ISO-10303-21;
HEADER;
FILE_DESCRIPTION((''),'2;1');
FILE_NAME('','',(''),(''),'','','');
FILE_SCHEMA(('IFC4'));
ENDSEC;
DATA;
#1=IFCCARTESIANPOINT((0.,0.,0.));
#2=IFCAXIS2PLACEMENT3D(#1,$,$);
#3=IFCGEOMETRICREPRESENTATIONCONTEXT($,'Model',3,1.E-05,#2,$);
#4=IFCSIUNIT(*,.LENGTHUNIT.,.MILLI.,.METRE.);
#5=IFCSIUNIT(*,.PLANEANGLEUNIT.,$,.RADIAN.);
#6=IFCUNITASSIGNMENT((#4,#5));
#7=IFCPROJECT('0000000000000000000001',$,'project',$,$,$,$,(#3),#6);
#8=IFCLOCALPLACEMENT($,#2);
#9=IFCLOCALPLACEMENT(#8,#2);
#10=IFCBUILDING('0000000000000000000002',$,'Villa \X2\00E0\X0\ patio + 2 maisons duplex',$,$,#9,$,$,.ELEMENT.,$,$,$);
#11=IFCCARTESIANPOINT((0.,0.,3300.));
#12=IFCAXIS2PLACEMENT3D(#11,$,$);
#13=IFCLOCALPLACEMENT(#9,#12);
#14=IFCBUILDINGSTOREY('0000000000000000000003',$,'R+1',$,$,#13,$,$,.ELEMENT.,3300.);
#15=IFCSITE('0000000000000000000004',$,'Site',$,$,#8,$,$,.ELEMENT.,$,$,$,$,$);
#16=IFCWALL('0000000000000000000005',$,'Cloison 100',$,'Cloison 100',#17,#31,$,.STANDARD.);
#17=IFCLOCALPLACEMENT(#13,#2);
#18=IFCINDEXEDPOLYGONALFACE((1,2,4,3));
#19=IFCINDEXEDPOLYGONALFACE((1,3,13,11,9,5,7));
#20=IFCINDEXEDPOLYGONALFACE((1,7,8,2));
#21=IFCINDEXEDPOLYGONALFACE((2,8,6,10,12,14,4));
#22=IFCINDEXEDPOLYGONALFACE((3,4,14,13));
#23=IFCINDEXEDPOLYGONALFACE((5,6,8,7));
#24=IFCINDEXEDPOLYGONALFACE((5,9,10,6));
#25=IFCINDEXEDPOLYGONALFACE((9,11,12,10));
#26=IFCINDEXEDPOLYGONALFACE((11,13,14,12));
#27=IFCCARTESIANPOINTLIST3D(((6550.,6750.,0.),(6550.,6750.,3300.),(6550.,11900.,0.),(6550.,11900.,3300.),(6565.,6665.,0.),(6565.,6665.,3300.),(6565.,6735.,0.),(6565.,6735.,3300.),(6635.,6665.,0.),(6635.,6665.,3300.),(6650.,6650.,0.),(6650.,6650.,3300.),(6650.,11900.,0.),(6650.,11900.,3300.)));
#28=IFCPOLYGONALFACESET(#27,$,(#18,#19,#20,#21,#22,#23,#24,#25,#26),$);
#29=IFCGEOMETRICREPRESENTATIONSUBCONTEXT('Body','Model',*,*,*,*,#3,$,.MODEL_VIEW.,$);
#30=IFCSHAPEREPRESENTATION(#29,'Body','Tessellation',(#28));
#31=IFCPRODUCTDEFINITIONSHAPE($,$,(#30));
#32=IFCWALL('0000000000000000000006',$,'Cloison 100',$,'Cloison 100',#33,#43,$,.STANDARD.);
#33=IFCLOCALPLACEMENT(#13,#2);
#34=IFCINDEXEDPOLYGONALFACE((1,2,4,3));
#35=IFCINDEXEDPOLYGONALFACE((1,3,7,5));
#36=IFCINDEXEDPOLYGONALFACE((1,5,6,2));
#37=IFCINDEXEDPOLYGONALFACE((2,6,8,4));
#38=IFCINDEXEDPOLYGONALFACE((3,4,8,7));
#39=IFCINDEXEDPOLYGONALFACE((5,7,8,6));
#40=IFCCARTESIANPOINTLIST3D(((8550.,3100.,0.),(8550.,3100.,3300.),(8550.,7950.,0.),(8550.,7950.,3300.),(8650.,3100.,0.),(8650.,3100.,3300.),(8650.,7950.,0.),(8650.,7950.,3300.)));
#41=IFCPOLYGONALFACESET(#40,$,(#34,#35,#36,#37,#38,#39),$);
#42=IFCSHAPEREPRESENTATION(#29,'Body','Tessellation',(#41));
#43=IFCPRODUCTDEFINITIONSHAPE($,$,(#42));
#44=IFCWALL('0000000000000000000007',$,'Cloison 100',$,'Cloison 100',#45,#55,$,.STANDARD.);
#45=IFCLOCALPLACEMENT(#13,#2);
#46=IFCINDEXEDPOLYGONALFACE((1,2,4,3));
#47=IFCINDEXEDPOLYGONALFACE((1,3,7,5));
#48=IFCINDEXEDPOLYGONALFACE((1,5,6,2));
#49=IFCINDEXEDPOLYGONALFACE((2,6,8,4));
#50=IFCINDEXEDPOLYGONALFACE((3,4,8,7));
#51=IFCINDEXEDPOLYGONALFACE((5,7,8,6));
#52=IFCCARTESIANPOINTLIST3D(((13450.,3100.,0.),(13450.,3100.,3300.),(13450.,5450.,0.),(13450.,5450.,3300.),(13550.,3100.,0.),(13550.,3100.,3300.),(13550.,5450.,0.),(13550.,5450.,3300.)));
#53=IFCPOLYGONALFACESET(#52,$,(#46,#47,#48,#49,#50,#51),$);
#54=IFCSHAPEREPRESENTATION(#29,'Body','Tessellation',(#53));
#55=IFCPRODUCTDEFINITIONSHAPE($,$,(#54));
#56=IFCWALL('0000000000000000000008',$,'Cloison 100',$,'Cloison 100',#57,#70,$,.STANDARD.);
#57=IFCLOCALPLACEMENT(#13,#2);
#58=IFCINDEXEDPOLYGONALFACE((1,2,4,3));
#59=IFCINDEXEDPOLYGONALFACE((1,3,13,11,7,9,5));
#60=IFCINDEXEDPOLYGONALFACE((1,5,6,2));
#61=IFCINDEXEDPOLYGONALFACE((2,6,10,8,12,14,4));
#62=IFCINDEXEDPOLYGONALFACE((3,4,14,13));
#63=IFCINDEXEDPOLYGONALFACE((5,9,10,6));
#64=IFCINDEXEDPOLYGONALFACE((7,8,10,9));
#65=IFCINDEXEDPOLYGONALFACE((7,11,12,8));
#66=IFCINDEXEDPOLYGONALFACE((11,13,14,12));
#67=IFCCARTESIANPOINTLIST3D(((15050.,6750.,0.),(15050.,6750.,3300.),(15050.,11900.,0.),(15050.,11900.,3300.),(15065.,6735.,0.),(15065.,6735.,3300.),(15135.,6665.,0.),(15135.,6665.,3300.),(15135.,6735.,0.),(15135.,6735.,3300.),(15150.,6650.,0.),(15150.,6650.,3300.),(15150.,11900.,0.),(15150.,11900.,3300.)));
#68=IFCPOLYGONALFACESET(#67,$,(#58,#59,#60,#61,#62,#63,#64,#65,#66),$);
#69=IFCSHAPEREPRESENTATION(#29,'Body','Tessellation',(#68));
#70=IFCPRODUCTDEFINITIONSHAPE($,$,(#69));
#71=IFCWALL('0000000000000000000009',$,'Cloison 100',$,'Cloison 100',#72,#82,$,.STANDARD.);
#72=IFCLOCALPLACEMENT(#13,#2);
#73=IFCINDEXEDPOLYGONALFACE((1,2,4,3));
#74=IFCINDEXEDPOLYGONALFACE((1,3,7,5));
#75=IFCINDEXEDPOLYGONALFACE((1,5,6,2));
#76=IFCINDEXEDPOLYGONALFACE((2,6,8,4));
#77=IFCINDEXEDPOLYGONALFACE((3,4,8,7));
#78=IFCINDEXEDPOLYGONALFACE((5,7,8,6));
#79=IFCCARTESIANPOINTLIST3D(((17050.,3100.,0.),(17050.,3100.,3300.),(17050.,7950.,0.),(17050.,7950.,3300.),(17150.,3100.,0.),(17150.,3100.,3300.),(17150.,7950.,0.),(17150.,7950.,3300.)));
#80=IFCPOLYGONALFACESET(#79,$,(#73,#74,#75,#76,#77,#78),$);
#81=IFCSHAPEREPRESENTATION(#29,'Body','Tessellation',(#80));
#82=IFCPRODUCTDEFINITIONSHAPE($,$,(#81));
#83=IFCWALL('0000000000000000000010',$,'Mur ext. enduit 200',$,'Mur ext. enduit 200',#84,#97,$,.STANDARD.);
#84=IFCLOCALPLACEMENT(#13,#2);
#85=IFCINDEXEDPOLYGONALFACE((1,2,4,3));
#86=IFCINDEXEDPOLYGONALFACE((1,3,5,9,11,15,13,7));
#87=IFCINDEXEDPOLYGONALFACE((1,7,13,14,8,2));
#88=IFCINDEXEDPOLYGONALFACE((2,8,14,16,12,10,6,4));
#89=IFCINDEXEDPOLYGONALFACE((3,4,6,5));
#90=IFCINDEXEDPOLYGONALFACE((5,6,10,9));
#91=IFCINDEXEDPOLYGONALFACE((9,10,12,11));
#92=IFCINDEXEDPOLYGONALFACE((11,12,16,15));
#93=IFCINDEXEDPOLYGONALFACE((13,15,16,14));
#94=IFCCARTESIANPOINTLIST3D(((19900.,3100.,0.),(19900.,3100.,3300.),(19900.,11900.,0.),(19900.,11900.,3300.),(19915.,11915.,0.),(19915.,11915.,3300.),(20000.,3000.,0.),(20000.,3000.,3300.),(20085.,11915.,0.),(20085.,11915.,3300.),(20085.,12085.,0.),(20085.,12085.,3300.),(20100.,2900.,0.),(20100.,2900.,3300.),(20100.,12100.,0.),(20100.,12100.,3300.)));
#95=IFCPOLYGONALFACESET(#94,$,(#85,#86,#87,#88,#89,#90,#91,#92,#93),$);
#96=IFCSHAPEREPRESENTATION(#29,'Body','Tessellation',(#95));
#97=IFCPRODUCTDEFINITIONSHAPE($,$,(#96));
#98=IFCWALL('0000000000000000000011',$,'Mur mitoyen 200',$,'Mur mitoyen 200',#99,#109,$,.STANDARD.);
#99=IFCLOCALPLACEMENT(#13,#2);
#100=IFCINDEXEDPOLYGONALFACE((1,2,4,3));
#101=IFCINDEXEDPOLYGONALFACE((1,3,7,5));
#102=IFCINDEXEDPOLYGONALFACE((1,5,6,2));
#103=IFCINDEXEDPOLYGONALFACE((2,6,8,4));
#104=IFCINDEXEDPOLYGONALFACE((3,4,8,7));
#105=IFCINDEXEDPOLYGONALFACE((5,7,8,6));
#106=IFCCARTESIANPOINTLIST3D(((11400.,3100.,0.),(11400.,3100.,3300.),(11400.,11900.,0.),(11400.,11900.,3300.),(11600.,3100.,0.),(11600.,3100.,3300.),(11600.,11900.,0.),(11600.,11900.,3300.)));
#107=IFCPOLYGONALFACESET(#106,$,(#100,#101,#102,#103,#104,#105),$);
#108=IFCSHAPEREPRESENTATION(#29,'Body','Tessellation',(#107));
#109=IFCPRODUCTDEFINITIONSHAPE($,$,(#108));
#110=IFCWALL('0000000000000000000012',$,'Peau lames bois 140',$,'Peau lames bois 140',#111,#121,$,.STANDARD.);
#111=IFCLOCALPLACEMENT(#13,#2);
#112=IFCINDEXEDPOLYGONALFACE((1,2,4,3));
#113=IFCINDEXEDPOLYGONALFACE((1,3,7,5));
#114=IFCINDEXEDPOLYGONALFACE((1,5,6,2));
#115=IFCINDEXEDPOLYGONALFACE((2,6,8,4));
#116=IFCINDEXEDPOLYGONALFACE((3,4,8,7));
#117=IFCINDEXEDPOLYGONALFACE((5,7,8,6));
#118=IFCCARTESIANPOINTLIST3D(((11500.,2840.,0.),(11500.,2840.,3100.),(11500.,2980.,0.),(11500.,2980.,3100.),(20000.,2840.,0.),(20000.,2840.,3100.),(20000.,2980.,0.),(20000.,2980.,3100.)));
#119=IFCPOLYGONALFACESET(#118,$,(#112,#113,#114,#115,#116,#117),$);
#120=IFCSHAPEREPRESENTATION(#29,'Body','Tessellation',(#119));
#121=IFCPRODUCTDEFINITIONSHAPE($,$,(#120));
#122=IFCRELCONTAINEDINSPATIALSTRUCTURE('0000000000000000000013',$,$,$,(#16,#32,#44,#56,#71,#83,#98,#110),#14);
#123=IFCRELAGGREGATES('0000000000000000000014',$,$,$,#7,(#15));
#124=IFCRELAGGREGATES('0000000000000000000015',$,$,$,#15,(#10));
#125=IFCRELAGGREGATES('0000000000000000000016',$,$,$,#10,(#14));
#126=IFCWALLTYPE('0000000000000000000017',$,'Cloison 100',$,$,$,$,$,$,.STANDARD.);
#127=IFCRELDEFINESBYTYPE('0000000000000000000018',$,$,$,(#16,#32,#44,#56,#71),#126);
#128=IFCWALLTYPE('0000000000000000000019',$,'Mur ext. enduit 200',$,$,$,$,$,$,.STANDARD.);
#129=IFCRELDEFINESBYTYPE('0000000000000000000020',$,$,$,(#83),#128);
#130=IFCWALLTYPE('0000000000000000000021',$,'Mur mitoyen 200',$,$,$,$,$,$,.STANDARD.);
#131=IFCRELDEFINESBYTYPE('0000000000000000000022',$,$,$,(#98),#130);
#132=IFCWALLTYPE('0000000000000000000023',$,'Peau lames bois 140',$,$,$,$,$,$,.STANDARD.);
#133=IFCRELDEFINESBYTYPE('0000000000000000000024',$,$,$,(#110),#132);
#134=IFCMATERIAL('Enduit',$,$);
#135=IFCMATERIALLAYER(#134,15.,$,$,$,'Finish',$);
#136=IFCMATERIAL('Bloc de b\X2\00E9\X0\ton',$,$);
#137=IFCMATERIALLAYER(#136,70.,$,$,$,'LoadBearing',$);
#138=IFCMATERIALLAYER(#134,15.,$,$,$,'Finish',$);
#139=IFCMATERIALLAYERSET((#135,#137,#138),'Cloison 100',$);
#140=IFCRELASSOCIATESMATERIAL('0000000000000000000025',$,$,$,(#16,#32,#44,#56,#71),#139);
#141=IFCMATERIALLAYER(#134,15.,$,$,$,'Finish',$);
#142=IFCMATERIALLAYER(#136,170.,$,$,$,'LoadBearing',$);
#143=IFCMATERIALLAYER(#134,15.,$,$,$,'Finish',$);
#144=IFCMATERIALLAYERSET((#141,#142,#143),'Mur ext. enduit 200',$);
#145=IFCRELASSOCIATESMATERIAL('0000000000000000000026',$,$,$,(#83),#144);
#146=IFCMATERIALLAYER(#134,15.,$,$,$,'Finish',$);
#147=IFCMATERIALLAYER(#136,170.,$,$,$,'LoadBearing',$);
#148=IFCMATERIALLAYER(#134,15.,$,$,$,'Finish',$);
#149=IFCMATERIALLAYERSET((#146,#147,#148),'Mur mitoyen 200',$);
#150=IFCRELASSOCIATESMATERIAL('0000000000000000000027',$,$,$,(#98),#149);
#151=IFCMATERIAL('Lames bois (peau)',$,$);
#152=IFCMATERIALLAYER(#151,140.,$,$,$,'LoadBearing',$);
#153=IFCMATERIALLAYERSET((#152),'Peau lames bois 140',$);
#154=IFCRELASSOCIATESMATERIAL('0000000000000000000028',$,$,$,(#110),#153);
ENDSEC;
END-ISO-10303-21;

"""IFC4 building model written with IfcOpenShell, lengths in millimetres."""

from ifc_helpers import new_model, si_unit, frame, origin, place, context, subcontext, project, spatial, polyline, outline, extrude, material, layer, layer_set, layer_usage, type_object, element, save


model = new_model("IFC4")

# Units and contexts
model_context = context("Model", 3, precision=1e-05, world=origin())
body_context = subcontext(model_context, "Body", "Model", "MODEL_VIEW")
ifc_project = project(units=[si_unit("LENGTHUNIT", "METRE", prefix="MILLI"), si_unit("PLANEANGLEUNIT", "RADIAN")], contexts=[model_context])

# Site, building, storey
site_placement = place(None, origin())
site = spatial("IfcSite", under=ifc_project, at=site_placement, Name="Site", CompositionType="ELEMENT")
building_placement = place(site_placement, origin())
building = spatial("IfcBuilding", under=site, at=building_placement, Name="Villa à patio + 2 maisons duplex", CompositionType="ELEMENT")
storey_placement = place(building_placement, frame((0.0, 0.0, 3300.0)))
storey = spatial("IfcBuildingStorey", under=building, at=storey_placement, Name="R+1", CompositionType="ELEMENT", Elevation=3300.0)

# Shared definitions
ifc_material_1 = material(Name="Enduit")
ifc_layer_1 = layer(ifc_material_1, 15.0, Category="Finish")
ifc_material_2 = material(Name="Bloc de béton")
ifc_layer_2 = layer(ifc_material_2, 70.0, Category="LoadBearing")
ifc_layer_3 = layer(ifc_material_1, 15.0, Category="Finish")
ifc_layer_set_1 = layer_set([ifc_layer_1, ifc_layer_2, ifc_layer_3], Name="Cloison 100")
ifc_layer_usage_1 = layer_usage(ifc_layer_set_1, "AXIS2", "NEGATIVE", 50.0)
wall_type_1 = type_object("IfcWallType", Name="Cloison 100", PredefinedType="STANDARD")

# Walls
wall_1_placement = place(storey_placement, frame((6600.0, 12000.0, 0.0), z_axis=(0.0, 0.0, 1.0), x_axis=(0.0, -1.0, 0.0)))
element("IfcWall", 1, at=wall_1_placement, inside=storey, type_object=wall_type_1, material=ifc_layer_usage_1, Name="Cloison 100", ObjectType="Cloison 100", PredefinedType="STANDARD", context=body_context, shape_type="SweptSolid", body=[
    extrude(outline(polyline([(100.0, -50.0), (100.0, 50.0), (5350.0, 50.0), (5335.0, 35.0), (5335.0, -35.0), (5265.0, -35.0), (5250.0, -50.0), (100.0, -50.0)])), origin(), (0.0, 0.0, 1.0), 3300.0),
])
wall_2_placement = place(storey_placement, frame((8600.0, 8000.0, 0.0), z_axis=(0.0, 0.0, 1.0), x_axis=(0.0, -1.0, 0.0)))
element("IfcWall", 2, at=wall_2_placement, inside=storey, type_object=wall_type_1, material=ifc_layer_usage_1, Name="Cloison 100", ObjectType="Cloison 100", PredefinedType="STANDARD", context=body_context, shape_type="SweptSolid", body=[
    extrude(outline(polyline([(50.0, -50.0), (50.0, 50.0), (4900.0, 50.0), (4900.0, -50.0), (50.0, -50.0)])), origin(), (0.0, 0.0, 1.0), 3300.0),
])
wall_3_placement = place(storey_placement, frame((13500.0, 5500.0, 0.0), z_axis=(0.0, 0.0, 1.0), x_axis=(0.0, -1.0, 0.0)))
element("IfcWall", 3, at=wall_3_placement, inside=storey, type_object=wall_type_1, material=ifc_layer_usage_1, Name="Cloison 100", ObjectType="Cloison 100", PredefinedType="STANDARD", context=body_context, shape_type="SweptSolid", body=[
    extrude(outline(polyline([(50.0, -50.0), (50.0, 50.0), (2400.0, 50.0), (2400.0, -50.0), (50.0, -50.0)])), origin(), (0.0, 0.0, 1.0), 3300.0),
])
wall_4_placement = place(storey_placement, frame((15100.0, 12000.0, 0.0), z_axis=(0.0, 0.0, 1.0), x_axis=(0.0, -1.0, 0.0)))
element("IfcWall", 4, at=wall_4_placement, inside=storey, type_object=wall_type_1, material=ifc_layer_usage_1, Name="Cloison 100", ObjectType="Cloison 100", PredefinedType="STANDARD", context=body_context, shape_type="SweptSolid", body=[
    extrude(outline(polyline([(100.0, -50.0), (100.0, 50.0), (5350.0, 50.0), (5335.0, 35.0), (5265.0, 35.0), (5265.0, -35.0), (5250.0, -50.0), (100.0, -50.0)])), origin(), (0.0, 0.0, 1.0), 3300.0),
])
wall_5_placement = place(storey_placement, frame((17100.0, 8000.0, 0.0), z_axis=(0.0, 0.0, 1.0), x_axis=(0.0, -1.0, 0.0)))
element("IfcWall", 5, at=wall_5_placement, inside=storey, type_object=wall_type_1, material=ifc_layer_usage_1, Name="Cloison 100", ObjectType="Cloison 100", PredefinedType="STANDARD", context=body_context, shape_type="SweptSolid", body=[
    extrude(outline(polyline([(50.0, -50.0), (50.0, 50.0), (4900.0, 50.0), (4900.0, -50.0), (50.0, -50.0)])), origin(), (0.0, 0.0, 1.0), 3300.0),
])
ifc_layer_4 = layer(ifc_material_1, 15.0, Category="Finish")
ifc_layer_5 = layer(ifc_material_2, 170.0, Category="LoadBearing")
ifc_layer_6 = layer(ifc_material_1, 15.0, Category="Finish")
ifc_layer_set_2 = layer_set([ifc_layer_4, ifc_layer_5, ifc_layer_6], Name="Mur ext. enduit 200")
ifc_layer_usage_2 = layer_usage(ifc_layer_set_2, "AXIS2", "NEGATIVE", 100.0)
wall_type_2 = type_object("IfcWallType", Name="Mur ext. enduit 200", PredefinedType="STANDARD")
wall_6_placement = place(storey_placement, frame((20000.0, 12000.0, 0.0), z_axis=(0.0, 0.0, 1.0), x_axis=(0.0, -1.0, 0.0)))
element("IfcWall", 6, at=wall_6_placement, inside=storey, type_object=wall_type_2, material=ifc_layer_usage_2, Name="Mur ext. enduit 200", ObjectType="Mur ext. enduit 200", PredefinedType="STANDARD", context=body_context, shape_type="SweptSolid", body=[
    extrude(outline(polyline([(100.0, -100.0), (85.0, -85.0), (85.0, 85.0), (-85.0, 85.0), (-100.0, 100.0), (9100.0, 100.0), (9000.0, 0.0), (8900.0, -100.0), (100.0, -100.0)])), origin(), (0.0, 0.0, 1.0), 3300.0),
])
ifc_layer_7 = layer(ifc_material_1, 15.0, Category="Finish")
ifc_layer_8 = layer(ifc_material_2, 170.0, Category="LoadBearing")
ifc_layer_9 = layer(ifc_material_1, 15.0, Category="Finish")
ifc_layer_set_3 = layer_set([ifc_layer_7, ifc_layer_8, ifc_layer_9], Name="Mur mitoyen 200")
ifc_layer_usage_3 = layer_usage(ifc_layer_set_3, "AXIS2", "NEGATIVE", 100.0)
wall_type_3 = type_object("IfcWallType", Name="Mur mitoyen 200", PredefinedType="STANDARD")
wall_7_placement = place(storey_placement, frame((11500.0, 12000.0, 0.0), z_axis=(0.0, 0.0, 1.0), x_axis=(0.0, -1.0, 0.0)))
element("IfcWall", 7, at=wall_7_placement, inside=storey, type_object=wall_type_3, material=ifc_layer_usage_3, Name="Mur mitoyen 200", ObjectType="Mur mitoyen 200", PredefinedType="STANDARD", context=body_context, shape_type="SweptSolid", body=[
    extrude(outline(polyline([(100.0, -100.0), (100.0, 100.0), (8900.0, 100.0), (8900.0, -100.0), (100.0, -100.0)])), origin(), (0.0, 0.0, 1.0), 3300.0),
])
ifc_material_3 = material(Name="Lames bois (peau)")
ifc_layer_10 = layer(ifc_material_3, 140.0, Category="LoadBearing")
ifc_layer_set_4 = layer_set([ifc_layer_10], Name="Peau lames bois 140")
ifc_layer_usage_4 = layer_usage(ifc_layer_set_4, "AXIS2", "NEGATIVE", 70.0)
wall_type_4 = type_object("IfcWallType", Name="Peau lames bois 140", PredefinedType="STANDARD")
wall_8_placement = place(storey_placement, frame((11500.0, 2910.0, 0.0), z_axis=(0.0, 0.0, 1.0), x_axis=(1.0, 0.0, 0.0)))
element("IfcWall", 8, at=wall_8_placement, inside=storey, type_object=wall_type_4, material=ifc_layer_usage_4, Name="Peau lames bois 140", ObjectType="Peau lames bois 140", PredefinedType="STANDARD", context=body_context, shape_type="SweptSolid", body=[
    extrude(outline(polyline([(0.0, -70.0), (0.0, 70.0), (8500.0, 70.0), (8500.0, -70.0), (0.0, -70.0)])), origin(), (0.0, 0.0, 1.0), 3100.0),
])

save(model, "model.ifc")
